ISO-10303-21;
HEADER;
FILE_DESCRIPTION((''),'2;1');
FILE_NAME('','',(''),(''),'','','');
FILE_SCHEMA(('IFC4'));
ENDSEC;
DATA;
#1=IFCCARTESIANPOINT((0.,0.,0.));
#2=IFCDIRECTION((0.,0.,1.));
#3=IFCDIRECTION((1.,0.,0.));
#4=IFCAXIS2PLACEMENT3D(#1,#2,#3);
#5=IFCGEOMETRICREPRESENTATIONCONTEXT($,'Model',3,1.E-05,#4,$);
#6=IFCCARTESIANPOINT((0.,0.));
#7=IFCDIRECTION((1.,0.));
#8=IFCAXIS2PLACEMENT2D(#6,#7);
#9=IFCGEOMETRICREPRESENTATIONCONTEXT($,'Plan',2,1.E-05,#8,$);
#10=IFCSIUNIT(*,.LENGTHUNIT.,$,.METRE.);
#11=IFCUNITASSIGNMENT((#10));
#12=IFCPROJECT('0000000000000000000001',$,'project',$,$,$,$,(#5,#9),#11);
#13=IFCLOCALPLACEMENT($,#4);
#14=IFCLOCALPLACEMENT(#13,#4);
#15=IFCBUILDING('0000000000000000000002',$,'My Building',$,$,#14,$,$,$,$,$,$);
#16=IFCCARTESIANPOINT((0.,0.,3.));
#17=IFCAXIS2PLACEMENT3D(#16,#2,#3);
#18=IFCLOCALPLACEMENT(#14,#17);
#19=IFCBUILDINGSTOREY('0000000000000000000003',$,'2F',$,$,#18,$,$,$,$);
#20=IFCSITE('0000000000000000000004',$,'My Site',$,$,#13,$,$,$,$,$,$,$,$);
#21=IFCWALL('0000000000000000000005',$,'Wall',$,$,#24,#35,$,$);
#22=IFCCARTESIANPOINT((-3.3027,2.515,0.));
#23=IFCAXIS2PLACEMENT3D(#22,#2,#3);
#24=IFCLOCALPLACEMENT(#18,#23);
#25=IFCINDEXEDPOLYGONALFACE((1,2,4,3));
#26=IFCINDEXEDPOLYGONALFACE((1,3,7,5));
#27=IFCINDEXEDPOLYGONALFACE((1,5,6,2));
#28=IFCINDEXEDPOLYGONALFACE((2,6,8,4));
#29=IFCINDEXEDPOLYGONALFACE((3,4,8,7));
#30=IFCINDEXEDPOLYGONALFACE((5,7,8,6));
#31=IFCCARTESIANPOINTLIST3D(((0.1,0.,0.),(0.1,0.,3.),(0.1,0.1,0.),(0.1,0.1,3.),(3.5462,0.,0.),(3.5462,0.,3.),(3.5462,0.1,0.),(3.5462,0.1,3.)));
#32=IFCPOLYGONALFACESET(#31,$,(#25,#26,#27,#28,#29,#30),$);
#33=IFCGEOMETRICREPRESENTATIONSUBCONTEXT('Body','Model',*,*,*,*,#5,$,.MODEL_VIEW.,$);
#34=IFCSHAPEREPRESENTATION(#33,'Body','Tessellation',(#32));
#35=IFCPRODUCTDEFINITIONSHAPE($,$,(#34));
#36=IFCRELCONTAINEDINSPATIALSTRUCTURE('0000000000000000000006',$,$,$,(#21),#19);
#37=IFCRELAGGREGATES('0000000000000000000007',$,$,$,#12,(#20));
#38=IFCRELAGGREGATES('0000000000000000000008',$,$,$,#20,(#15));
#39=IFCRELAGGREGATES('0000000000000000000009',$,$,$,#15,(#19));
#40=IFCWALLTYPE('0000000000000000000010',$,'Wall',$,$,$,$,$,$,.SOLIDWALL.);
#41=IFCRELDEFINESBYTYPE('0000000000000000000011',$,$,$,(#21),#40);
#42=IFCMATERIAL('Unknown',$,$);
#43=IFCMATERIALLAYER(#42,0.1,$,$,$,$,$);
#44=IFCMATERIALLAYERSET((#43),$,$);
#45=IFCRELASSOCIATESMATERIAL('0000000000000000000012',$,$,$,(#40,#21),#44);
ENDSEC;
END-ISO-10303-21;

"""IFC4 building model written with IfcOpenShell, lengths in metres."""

from ifc_helpers import new_model, si_unit, frame, origin_with_axes, origin_2d_with_axis, place, context, subcontext, project, spatial, line, indexed_curve, outline, extrude, material, layer, layer_set, layer_usage, type_object, element, save


model = new_model("IFC4")

# Units and contexts
model_context = context("Model", 3, precision=1e-05, world=origin_with_axes())
plan_context = context("Plan", 2, precision=1e-05, world=origin_2d_with_axis())
body_context_1 = subcontext(model_context, "Body", "Model", "MODEL_VIEW")
ifc_project = project(units=[si_unit("LENGTHUNIT", "METRE")], contexts=[model_context, plan_context])

# Site, building, storey
site_placement = place(None, origin_with_axes())
site = spatial("IfcSite", under=ifc_project, at=site_placement, Name="My Site")
building_placement = place(site_placement, origin_with_axes())
building = spatial("IfcBuilding", under=site, at=building_placement, Name="My Building")
storey_placement = place(building_placement, frame((0.0, 0.0, 3.0), z_axis=(0.0, 0.0, 1.0), x_axis=(1.0, 0.0, 0.0)))
storey = spatial("IfcBuildingStorey", under=building, at=storey_placement, Name="2F")

# Shared definitions
ifc_material = material(Name="Unknown")

# Shared definitions
ifc_layer = layer(ifc_material, 0.1)
ifc_layer_set = layer_set([ifc_layer])
wall_type = type_object("IfcWallType", Name="Wall", PredefinedType="SOLIDWALL", material=ifc_layer_set)

# Wall
ifc_layer_usage_1 = layer_usage(ifc_layer_set, "AXIS2", "POSITIVE", 0.0)
wall_1_placement = place(storey_placement, frame((-3.3027, 2.515, 0.0), z_axis=(0.0, 0.0, 1.0), x_axis=(1.0, 0.0, 0.0)))
element("IfcWall", 1, at=wall_1_placement, inside=storey, type_object=wall_type, material=ifc_layer_usage_1, Name="Wall", context=body_context_1, shape_type="SweptSolid", body=[
    extrude(outline(indexed_curve([(0.1, 0.0), (0.1, 0.1), (3.5462, 0.1), (3.5462, 0.0)], segments=[line(1, 2, 3, 4, 1)])), origin_with_axes(), (0.0, 0.0, 1.0), 3.0),
])

save(model, "model.ifc")
